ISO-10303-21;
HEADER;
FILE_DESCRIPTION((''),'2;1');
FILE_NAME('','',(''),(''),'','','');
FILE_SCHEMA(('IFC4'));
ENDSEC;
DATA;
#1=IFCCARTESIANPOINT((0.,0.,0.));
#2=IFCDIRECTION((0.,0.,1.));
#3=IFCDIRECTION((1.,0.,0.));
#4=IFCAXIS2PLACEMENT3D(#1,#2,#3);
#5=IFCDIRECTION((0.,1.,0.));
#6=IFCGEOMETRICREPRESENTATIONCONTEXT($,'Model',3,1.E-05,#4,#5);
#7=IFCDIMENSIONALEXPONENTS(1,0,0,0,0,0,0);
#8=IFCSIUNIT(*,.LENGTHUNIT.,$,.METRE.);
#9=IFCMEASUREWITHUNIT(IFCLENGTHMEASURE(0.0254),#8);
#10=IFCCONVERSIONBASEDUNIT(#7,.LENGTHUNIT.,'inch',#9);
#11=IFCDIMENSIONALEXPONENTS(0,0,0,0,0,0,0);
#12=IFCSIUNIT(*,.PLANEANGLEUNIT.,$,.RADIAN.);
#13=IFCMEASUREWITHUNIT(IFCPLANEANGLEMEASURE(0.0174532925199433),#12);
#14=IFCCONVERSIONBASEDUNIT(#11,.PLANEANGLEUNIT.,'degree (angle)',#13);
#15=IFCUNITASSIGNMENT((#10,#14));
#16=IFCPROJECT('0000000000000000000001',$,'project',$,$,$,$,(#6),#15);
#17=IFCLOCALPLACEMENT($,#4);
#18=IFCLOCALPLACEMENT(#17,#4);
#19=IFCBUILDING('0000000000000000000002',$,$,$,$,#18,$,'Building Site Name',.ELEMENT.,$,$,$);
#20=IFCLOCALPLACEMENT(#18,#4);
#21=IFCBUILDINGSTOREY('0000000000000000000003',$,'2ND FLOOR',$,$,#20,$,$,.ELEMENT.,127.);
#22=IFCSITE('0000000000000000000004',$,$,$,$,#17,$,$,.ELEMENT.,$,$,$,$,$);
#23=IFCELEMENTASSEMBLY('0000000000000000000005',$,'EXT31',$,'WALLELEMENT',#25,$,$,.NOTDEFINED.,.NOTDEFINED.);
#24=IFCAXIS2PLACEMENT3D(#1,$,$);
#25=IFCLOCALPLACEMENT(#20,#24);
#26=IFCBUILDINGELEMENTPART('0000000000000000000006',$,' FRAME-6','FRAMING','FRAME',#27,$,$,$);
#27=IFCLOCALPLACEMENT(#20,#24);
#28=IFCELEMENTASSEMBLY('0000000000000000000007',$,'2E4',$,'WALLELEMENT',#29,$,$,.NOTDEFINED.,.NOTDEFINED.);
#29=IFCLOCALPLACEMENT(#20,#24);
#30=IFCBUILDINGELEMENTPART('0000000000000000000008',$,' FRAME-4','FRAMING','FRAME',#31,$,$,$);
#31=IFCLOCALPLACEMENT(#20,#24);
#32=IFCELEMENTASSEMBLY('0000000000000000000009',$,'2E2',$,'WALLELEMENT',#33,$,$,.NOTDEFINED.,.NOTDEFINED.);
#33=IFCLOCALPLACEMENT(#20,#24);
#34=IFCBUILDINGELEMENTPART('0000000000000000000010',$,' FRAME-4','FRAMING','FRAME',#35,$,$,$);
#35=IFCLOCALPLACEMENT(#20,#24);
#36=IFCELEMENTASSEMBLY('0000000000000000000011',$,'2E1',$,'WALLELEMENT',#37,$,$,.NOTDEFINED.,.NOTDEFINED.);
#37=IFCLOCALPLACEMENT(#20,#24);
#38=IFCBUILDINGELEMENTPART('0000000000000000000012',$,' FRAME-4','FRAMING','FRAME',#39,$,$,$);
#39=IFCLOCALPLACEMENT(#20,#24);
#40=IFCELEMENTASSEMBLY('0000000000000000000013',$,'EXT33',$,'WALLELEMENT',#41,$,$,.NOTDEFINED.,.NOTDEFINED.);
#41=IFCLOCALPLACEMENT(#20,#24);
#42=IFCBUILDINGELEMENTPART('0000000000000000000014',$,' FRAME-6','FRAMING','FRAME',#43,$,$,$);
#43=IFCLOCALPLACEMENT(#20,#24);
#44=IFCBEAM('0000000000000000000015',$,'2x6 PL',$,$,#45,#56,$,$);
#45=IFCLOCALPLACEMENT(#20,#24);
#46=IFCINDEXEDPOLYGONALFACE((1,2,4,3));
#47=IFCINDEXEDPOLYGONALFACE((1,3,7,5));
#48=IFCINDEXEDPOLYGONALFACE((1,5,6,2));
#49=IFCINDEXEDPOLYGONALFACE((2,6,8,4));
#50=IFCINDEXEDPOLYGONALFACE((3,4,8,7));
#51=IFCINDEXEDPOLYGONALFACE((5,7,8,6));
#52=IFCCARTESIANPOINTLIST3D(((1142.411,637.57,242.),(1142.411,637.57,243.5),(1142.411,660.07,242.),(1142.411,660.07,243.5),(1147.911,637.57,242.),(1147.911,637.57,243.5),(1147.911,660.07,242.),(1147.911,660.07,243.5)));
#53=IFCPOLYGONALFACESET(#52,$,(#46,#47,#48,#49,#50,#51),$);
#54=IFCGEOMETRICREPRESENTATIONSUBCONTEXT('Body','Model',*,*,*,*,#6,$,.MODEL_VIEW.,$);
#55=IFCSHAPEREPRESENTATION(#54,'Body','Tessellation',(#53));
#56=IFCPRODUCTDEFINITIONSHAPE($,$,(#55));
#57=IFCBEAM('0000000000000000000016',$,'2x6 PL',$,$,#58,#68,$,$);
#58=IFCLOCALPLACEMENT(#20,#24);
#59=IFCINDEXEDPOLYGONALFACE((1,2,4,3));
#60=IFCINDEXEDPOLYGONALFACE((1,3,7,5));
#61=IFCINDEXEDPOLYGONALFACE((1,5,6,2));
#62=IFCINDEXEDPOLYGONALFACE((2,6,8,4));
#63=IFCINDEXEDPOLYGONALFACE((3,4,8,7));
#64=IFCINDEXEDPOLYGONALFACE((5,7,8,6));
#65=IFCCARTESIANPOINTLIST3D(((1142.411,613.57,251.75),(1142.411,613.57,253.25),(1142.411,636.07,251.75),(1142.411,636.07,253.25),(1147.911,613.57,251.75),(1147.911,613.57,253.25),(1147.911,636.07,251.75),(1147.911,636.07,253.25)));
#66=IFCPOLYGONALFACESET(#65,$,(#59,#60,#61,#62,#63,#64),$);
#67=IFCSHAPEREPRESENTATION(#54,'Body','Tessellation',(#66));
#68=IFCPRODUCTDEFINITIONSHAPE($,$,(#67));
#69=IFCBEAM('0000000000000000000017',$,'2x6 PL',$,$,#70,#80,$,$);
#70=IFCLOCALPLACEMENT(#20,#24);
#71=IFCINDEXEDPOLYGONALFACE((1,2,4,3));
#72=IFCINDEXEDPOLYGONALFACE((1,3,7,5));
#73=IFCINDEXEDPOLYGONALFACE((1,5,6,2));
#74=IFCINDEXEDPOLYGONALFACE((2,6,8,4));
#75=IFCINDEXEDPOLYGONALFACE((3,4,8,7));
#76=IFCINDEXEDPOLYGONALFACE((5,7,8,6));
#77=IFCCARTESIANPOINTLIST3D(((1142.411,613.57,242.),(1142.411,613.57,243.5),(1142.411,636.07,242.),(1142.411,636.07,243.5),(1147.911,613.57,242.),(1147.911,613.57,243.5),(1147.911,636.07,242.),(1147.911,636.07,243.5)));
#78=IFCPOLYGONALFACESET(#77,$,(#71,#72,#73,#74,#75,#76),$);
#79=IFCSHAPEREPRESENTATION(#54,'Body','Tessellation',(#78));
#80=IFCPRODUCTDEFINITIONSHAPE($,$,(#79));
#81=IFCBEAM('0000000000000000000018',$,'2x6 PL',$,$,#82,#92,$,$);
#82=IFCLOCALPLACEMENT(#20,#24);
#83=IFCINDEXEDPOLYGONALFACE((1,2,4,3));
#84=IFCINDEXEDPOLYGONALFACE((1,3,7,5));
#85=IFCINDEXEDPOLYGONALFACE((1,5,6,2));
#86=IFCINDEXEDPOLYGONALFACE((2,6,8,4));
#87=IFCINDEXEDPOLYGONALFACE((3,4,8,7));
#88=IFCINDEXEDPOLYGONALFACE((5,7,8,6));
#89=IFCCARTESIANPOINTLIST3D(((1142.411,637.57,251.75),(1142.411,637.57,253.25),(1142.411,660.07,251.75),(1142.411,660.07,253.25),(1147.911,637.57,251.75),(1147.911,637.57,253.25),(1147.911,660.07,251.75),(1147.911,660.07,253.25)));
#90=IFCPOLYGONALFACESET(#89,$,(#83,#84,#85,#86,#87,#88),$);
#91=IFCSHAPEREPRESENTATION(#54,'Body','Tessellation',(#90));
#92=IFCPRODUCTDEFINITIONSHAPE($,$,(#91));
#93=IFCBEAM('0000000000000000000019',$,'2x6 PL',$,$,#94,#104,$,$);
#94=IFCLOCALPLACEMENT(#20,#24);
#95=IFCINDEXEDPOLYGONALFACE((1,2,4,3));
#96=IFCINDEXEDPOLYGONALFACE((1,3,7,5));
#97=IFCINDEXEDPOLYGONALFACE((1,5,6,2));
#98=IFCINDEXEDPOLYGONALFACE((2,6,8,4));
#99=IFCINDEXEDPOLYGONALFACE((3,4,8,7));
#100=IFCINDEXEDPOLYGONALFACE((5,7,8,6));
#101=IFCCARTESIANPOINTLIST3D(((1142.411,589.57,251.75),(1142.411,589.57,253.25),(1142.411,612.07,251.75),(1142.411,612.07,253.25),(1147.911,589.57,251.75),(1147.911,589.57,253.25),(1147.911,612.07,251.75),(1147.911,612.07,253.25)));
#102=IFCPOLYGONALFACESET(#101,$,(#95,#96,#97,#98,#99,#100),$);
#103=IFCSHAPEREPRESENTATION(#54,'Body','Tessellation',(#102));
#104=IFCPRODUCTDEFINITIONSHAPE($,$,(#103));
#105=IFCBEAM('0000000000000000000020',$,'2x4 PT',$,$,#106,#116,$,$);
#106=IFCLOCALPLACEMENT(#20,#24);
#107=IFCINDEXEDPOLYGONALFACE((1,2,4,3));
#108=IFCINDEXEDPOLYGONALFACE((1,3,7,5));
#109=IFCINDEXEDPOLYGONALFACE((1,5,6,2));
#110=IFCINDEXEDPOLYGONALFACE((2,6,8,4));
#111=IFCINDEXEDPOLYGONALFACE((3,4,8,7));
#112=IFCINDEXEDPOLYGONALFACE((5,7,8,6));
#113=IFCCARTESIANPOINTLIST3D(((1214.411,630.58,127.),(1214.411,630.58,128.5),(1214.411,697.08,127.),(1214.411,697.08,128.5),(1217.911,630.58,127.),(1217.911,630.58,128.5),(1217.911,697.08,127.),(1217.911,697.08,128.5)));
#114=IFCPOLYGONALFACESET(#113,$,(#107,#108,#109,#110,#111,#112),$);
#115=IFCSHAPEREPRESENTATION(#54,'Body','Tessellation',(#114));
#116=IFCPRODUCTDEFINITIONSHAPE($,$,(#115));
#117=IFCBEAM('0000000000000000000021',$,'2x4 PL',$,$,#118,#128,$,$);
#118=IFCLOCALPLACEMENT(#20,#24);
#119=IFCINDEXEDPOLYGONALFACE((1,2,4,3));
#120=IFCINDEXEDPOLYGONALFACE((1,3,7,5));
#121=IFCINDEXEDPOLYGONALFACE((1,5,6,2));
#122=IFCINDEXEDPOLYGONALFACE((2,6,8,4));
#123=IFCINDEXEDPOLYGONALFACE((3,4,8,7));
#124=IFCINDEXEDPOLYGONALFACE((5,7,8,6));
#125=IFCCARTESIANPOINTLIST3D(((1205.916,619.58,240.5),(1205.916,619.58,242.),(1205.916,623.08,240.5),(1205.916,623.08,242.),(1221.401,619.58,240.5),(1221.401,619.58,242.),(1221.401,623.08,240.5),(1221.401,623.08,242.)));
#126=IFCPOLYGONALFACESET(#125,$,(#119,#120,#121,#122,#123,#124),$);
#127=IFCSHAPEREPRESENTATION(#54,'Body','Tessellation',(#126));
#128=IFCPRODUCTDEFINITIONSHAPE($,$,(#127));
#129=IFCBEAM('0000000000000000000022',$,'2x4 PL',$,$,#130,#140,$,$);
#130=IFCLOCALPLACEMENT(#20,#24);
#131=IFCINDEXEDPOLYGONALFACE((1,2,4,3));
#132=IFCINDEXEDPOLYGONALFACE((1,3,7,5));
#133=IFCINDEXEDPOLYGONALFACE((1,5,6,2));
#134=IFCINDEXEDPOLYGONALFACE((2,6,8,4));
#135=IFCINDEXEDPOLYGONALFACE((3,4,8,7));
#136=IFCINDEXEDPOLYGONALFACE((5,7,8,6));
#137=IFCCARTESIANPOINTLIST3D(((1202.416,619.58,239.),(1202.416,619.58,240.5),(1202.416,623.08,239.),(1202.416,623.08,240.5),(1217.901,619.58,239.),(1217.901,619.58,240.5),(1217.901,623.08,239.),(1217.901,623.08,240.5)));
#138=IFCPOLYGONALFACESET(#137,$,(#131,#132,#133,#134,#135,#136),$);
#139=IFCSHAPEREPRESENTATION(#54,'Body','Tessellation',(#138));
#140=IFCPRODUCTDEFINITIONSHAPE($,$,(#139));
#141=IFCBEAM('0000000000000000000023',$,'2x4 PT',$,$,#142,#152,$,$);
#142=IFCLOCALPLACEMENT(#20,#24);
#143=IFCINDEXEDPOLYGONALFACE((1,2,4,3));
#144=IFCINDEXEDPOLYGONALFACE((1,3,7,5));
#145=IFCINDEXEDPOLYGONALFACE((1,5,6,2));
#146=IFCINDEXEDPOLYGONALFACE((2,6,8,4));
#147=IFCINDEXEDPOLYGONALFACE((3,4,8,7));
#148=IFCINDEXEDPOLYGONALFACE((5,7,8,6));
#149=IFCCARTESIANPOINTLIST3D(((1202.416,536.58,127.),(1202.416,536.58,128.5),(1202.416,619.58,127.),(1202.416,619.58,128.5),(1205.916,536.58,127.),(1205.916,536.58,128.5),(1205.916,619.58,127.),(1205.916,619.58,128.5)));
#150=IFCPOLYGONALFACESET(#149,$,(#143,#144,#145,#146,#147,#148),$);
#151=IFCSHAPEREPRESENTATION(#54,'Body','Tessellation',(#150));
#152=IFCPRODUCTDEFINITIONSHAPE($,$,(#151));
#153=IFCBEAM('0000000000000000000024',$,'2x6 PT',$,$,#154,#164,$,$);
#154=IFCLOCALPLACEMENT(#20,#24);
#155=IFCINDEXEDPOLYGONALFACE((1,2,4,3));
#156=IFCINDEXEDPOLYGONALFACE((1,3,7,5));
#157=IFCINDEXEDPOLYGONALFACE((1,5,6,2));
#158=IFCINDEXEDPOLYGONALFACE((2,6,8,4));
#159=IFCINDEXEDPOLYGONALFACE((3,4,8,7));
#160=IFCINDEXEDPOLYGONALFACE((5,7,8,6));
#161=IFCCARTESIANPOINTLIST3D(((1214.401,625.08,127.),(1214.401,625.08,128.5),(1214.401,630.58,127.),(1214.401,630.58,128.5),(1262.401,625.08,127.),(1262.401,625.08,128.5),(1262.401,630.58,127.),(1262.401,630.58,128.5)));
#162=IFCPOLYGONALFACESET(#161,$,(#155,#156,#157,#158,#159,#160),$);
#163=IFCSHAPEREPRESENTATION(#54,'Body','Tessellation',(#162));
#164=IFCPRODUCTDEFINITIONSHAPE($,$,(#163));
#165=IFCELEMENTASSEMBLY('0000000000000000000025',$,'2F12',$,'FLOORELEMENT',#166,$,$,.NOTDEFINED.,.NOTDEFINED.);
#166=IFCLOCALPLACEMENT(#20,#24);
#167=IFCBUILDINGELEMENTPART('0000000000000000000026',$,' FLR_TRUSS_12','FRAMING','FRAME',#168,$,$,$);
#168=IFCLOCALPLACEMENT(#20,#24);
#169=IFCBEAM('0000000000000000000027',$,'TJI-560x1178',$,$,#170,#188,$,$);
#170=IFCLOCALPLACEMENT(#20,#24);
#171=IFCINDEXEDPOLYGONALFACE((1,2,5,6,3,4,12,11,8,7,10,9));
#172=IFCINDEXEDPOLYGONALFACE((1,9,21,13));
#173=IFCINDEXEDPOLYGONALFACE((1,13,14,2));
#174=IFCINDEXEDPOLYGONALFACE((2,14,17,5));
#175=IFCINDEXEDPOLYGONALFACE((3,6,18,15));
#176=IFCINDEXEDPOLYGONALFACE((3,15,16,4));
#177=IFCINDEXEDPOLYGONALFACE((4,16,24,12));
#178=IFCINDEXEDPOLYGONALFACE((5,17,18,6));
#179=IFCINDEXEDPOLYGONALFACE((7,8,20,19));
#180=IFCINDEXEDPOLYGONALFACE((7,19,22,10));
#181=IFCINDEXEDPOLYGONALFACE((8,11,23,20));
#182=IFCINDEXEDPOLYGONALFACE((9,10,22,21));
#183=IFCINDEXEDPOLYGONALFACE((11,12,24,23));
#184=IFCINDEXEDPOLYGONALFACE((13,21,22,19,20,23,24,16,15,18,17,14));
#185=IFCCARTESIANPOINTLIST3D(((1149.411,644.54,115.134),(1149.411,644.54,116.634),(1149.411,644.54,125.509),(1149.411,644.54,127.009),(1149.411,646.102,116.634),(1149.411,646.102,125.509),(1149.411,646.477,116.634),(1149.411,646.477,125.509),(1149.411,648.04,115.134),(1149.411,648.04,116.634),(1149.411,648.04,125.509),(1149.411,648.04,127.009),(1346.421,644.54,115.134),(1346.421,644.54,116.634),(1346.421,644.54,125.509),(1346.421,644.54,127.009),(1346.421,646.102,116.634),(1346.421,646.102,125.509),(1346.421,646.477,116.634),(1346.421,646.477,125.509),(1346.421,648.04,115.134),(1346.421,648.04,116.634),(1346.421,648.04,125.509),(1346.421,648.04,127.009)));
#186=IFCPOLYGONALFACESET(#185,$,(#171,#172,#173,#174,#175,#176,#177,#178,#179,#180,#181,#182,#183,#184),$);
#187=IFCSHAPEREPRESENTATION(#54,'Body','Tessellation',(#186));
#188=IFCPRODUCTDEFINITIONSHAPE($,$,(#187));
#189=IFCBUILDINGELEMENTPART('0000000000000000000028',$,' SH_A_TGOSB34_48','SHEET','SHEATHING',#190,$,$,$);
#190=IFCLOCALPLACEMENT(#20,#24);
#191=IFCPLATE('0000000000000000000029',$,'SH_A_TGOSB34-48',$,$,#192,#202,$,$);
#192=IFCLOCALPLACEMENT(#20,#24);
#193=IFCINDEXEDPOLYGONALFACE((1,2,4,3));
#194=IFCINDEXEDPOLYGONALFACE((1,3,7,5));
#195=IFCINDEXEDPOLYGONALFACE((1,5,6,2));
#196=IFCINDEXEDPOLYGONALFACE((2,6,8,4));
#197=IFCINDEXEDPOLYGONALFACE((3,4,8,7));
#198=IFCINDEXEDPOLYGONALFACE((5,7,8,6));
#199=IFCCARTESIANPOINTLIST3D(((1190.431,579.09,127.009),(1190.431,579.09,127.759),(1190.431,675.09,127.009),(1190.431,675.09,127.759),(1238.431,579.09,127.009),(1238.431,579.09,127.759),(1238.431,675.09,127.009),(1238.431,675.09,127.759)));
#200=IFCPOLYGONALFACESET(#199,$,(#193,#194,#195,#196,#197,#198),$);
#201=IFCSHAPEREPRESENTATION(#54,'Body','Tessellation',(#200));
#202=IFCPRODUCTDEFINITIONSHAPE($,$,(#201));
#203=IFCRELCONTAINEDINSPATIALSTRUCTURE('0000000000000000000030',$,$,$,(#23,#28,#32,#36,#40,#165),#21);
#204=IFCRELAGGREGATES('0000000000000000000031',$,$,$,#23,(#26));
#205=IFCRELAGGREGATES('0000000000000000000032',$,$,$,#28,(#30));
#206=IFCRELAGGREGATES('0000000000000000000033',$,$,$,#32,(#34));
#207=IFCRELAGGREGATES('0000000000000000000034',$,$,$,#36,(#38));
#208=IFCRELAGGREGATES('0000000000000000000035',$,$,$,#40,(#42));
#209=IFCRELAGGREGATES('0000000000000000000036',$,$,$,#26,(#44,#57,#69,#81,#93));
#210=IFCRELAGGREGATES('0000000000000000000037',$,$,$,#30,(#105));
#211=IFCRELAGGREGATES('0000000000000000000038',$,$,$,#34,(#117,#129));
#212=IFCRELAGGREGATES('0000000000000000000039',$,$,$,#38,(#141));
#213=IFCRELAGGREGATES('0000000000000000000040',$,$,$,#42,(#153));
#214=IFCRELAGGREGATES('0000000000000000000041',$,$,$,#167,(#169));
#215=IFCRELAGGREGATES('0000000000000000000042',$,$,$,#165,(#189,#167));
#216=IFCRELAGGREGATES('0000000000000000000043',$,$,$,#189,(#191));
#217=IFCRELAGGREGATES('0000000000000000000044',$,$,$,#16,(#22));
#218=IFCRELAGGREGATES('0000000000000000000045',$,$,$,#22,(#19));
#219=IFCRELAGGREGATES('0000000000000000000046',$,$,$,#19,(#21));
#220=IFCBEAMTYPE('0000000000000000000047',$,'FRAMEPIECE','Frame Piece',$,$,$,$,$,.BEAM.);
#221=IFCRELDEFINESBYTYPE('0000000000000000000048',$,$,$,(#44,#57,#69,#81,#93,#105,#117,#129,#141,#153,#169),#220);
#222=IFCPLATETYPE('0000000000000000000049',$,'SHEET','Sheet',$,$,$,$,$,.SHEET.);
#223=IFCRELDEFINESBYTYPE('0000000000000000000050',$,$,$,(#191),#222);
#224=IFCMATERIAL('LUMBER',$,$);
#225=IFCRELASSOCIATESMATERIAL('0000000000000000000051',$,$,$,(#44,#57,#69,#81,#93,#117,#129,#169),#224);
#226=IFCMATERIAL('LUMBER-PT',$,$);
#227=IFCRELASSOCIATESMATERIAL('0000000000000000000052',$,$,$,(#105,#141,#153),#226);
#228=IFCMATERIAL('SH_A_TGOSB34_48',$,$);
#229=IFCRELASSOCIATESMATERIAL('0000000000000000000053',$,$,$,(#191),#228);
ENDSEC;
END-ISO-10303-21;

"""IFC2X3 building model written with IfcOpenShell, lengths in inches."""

from ifc_helpers import new_model, entity, si_unit, converted_unit, direction, frame, frame_2d, origin_with_axes, origin_2d_with_axis, place, context, subcontext, project, spatial, rectangle, i_section, extrude, material, type_object, element, aggregate, save


model = new_model("IFC2X3")

# Units and contexts
model_context = context("Model", 3, precision=1e-05, world=origin_with_axes(), true_north=direction((0.0, 1.0, 0.0)))
body_context = subcontext(model_context, "Body", "Model", "MODEL_VIEW")
ifc_project = project(units=[converted_unit("LENGTHUNIT", "inch", entity("IfcLengthMeasure", 0.0254), si_unit("LENGTHUNIT", "METRE"), dimensions=[1, 0, 0, 0, 0, 0, 0]), converted_unit("PLANEANGLEUNIT", "degree (angle)", entity("IfcPlaneAngleMeasure", 0.0174532925199433), si_unit("PLANEANGLEUNIT", "RADIAN"), dimensions=[0, 0, 0, 0, 0, 0, 0])], contexts=[model_context])

# Site, building, storey
site_placement = place(None, origin_with_axes())
site = spatial("IfcSite", under=ifc_project, at=site_placement, CompositionType="ELEMENT")
building_placement = place(site_placement, origin_with_axes())
building = spatial("IfcBuilding", under=site, at=building_placement, LongName="Building Site Name", CompositionType="ELEMENT")
storey_placement = place(building_placement, origin_with_axes())
storey = spatial("IfcBuildingStorey", under=building, at=storey_placement, Name="2ND FLOOR", CompositionType="ELEMENT", Elevation=127.0)

# Element assemblies, building element parts
assembly_1_placement = place(storey_placement, origin_with_axes())
assembly_1 = element("IfcElementAssembly", 1, at=assembly_1_placement, inside=storey, Name="EXT31", ObjectType="WALLELEMENT", AssemblyPlace="NOTDEFINED", PredefinedType="NOTDEFINED")
building_element_part_1 = element("IfcBuildingElementPart", 2, Name=" FRAME-6", Description="FRAMING", ObjectType="FRAME")
aggregate(assembly_1, [building_element_part_1])
ifc_material_1 = material(Name="LUMBER")
beam_type_1 = type_object("IfcBeamType", Name="FRAMEPIECE", Description="Frame Piece", PredefinedType="BEAM")
assembly_2_placement = place(storey_placement, origin_with_axes())
assembly_2 = element("IfcElementAssembly", 3, at=assembly_2_placement, inside=storey, Name="2E4", ObjectType="WALLELEMENT", AssemblyPlace="NOTDEFINED", PredefinedType="NOTDEFINED")
building_element_part_2 = element("IfcBuildingElementPart", 4, Name=" FRAME-4", Description="FRAMING", ObjectType="FRAME")
aggregate(assembly_2, [building_element_part_2])
assembly_3_placement = place(storey_placement, origin_with_axes())
assembly_3 = element("IfcElementAssembly", 5, at=assembly_3_placement, inside=storey, Name="2E2", ObjectType="WALLELEMENT", AssemblyPlace="NOTDEFINED", PredefinedType="NOTDEFINED")
building_element_part_3 = element("IfcBuildingElementPart", 6, Name=" FRAME-4", Description="FRAMING", ObjectType="FRAME")
aggregate(assembly_3, [building_element_part_3])
assembly_4_placement = place(storey_placement, origin_with_axes())
assembly_4 = element("IfcElementAssembly", 7, at=assembly_4_placement, inside=storey, Name="2E1", ObjectType="WALLELEMENT", AssemblyPlace="NOTDEFINED", PredefinedType="NOTDEFINED")
building_element_part_4 = element("IfcBuildingElementPart", 8, Name=" FRAME-4", Description="FRAMING", ObjectType="FRAME")
aggregate(assembly_4, [building_element_part_4])

# Element assembly, building element part
assembly_5_placement = place(storey_placement, origin_with_axes())
assembly_5 = element("IfcElementAssembly", 9, at=assembly_5_placement, inside=storey, Name="EXT33", ObjectType="WALLELEMENT", AssemblyPlace="NOTDEFINED", PredefinedType="NOTDEFINED")
building_element_part_5 = element("IfcBuildingElementPart", 10, Name=" FRAME-6", Description="FRAMING", ObjectType="FRAME")
aggregate(assembly_5, [building_element_part_5])

# Beams
beam_1_placement = place(assembly_1_placement, frame((1145.161, 637.57, 242.75), z_axis=(0.0, 1.0, 0.0), x_axis=(0.0, 0.0, -1.0)))
beam_1 = element("IfcBeam", 11, at=beam_1_placement, type_object=beam_type_1, material=ifc_material_1, Name="2x6 PL", context=body_context, shape_type="SweptSolid", body=[
    extrude(rectangle(XDim=1.5, YDim=5.5, at=frame_2d((0.0, 0.0), x_axis=(-1.0, 0.0))), origin_with_axes(), (0.0, 0.0, 1.0), 22.5),
])
beam_2_placement = place(assembly_1_placement, frame((1145.161, 613.57, 252.5), z_axis=(0.0, 1.0, 0.0), x_axis=(0.0, 0.0, -1.0)))
beam_2 = element("IfcBeam", 12, at=beam_2_placement, type_object=beam_type_1, material=ifc_material_1, Name="2x6 PL", context=body_context, shape_type="SweptSolid", body=[
    extrude(rectangle(XDim=1.5, YDim=5.5, at=frame_2d((0.0, 0.0), x_axis=(-1.0, 0.0))), origin_with_axes(), (0.0, 0.0, 1.0), 22.5),
])
beam_3_placement = place(assembly_1_placement, frame((1145.161, 613.57, 242.75), z_axis=(0.0, 1.0, 0.0), x_axis=(0.0, 0.0, -1.0)))
beam_3 = element("IfcBeam", 13, at=beam_3_placement, type_object=beam_type_1, material=ifc_material_1, Name="2x6 PL", context=body_context, shape_type="SweptSolid", body=[
    extrude(rectangle(XDim=1.5, YDim=5.5, at=frame_2d((0.0, 0.0), x_axis=(-1.0, 0.0))), origin_with_axes(), (0.0, 0.0, 1.0), 22.5),
])
beam_4_placement = place(assembly_1_placement, frame((1145.161, 637.57, 252.5), z_axis=(0.0, 1.0, 0.0), x_axis=(0.0, 0.0, -1.0)))
beam_4 = element("IfcBeam", 14, at=beam_4_placement, type_object=beam_type_1, material=ifc_material_1, Name="2x6 PL", context=body_context, shape_type="SweptSolid", body=[
    extrude(rectangle(XDim=1.5, YDim=5.5, at=frame_2d((0.0, 0.0), x_axis=(-1.0, 0.0))), origin_with_axes(), (0.0, 0.0, 1.0), 22.5),
])
beam_5_placement = place(assembly_1_placement, frame((1145.161, 589.57, 252.5), z_axis=(0.0, 1.0, 0.0), x_axis=(0.0, 0.0, -1.0)))
beam_5 = element("IfcBeam", 15, at=beam_5_placement, type_object=beam_type_1, material=ifc_material_1, Name="2x6 PL", context=body_context, shape_type="SweptSolid", body=[
    extrude(rectangle(XDim=1.5, YDim=5.5, at=frame_2d((0.0, 0.0), x_axis=(-1.0, 0.0))), origin_with_axes(), (0.0, 0.0, 1.0), 22.5),
])
aggregate(building_element_part_1, [beam_1, beam_2, beam_3, beam_4, beam_5])
ifc_material_2 = material(Name="LUMBER-PT")
beam_6_placement = place(assembly_2_placement, frame((1216.161, 630.58, 127.75), z_axis=(0.0, 1.0, 0.0), x_axis=(0.0, 0.0, 1.0)))
beam_6 = element("IfcBeam", 16, at=beam_6_placement, type_object=beam_type_1, material=ifc_material_2, Name="2x4 PT", context=body_context, shape_type="SweptSolid", body=[
    extrude(rectangle(XDim=1.5, YDim=3.5, at=frame_2d((0.0, 0.0), x_axis=(-1.0, 0.0))), origin_with_axes(), (0.0, 0.0, 1.0), 66.5),
])
aggregate(building_element_part_2, [beam_6])
beam_7_placement = place(assembly_3_placement, frame((1205.916, 621.33, 241.25), z_axis=(1.0, 0.0, 0.0), x_axis=(0.0, 0.0, -1.0)))
beam_7 = element("IfcBeam", 17, at=beam_7_placement, type_object=beam_type_1, material=ifc_material_1, Name="2x4 PL", context=body_context, shape_type="SweptSolid", body=[
    extrude(rectangle(XDim=1.5, YDim=3.5, at=frame_2d((0.0, 0.0), x_axis=(-1.0, 0.0))), frame((0.0, 0.0, 0.0), z_axis=(0.0, 0.0, 1.0), x_axis=(1.0, 0.0, 0.0)), (0.0, 0.0, 1.0), 15.485),
])
beam_8_placement = place(assembly_3_placement, frame((1202.416, 621.33, 239.75), z_axis=(1.0, 0.0, 0.0), x_axis=(0.0, 0.0, -1.0)))
beam_8 = element("IfcBeam", 18, at=beam_8_placement, type_object=beam_type_1, material=ifc_material_1, Name="2x4 PL", context=body_context, shape_type="SweptSolid", body=[
    extrude(rectangle(XDim=1.5, YDim=3.5, at=frame_2d((0.0, 0.0), x_axis=(-1.0, 0.0))), frame((0.0, 0.0, 0.0), z_axis=(0.0, 0.0, 1.0), x_axis=(1.0, 0.0, 0.0)), (0.0, 0.0, 1.0), 15.485),
])
aggregate(building_element_part_3, [beam_7, beam_8])
beam_9_placement = place(assembly_4_placement, frame((1204.166, 619.58, 127.75), z_axis=(0.0, -1.0, 0.0), x_axis=(0.0, 0.0, 1.0)))
beam_9 = element("IfcBeam", 19, at=beam_9_placement, type_object=beam_type_1, material=ifc_material_2, Name="2x4 PT", context=body_context, shape_type="SweptSolid", body=[
    extrude(rectangle(XDim=1.5, YDim=3.5, at=frame_2d((0.0, 0.0), x_axis=(-1.0, 0.0))), origin_with_axes(), (0.0, 0.0, 1.0), 83.0),
])
aggregate(building_element_part_4, [beam_9])
beam_10_placement = place(assembly_5_placement, frame((1214.401, 627.83, 127.75), z_axis=(1.0, 0.0, 0.0), x_axis=(0.0, 0.0, 1.0)))
beam_10 = element("IfcBeam", 20, at=beam_10_placement, type_object=beam_type_1, material=ifc_material_2, Name="2x6 PT", context=body_context, shape_type="SweptSolid", body=[
    extrude(rectangle(XDim=1.5, YDim=5.5, at=frame_2d((0.0, 0.0), x_axis=(-1.0, 0.0))), frame((0.0, 0.0, 0.0), z_axis=(0.0, 0.0, 1.0), x_axis=(1.0, 0.0, 0.0)), (0.0, 0.0, 1.0), 48.0),
])
aggregate(building_element_part_5, [beam_10])

# Element assembly, building element parts, beam, plate
assembly_6_placement = place(storey_placement, origin_with_axes())
assembly_6 = element("IfcElementAssembly", 21, at=assembly_6_placement, inside=storey, Name="2F12", ObjectType="FLOORELEMENT", AssemblyPlace="NOTDEFINED", PredefinedType="NOTDEFINED")
building_element_part_6 = element("IfcBuildingElementPart", 22, Name=" FLR_TRUSS_12", Description="FRAMING", ObjectType="FRAME")
beam_11_placement = place(assembly_6_placement, frame((1149.411, 646.29, 121.071), z_axis=(1.0, 0.0, 0.0), x_axis=(0.0, 1.0, 0.0)))
beam_11 = element("IfcBeam", 23, at=beam_11_placement, type_object=beam_type_1, material=ifc_material_1, Name="TJI-560x1178", context=body_context, shape_type="SweptSolid", body=[
    extrude(i_section(OverallWidth=3.5, OverallDepth=11.875, WebThickness=0.375, FlangeThickness=1.5, FilletRadius=0.0, at=origin_2d_with_axis()), frame((0.0, 0.0, 0.0), z_axis=(0.0, 0.0, 1.0), x_axis=(1.0, 0.0, 0.0)), (0.0, 0.0, 1.0), 197.01),
])
aggregate(building_element_part_6, [beam_11])
building_element_part_7 = element("IfcBuildingElementPart", 24, Name=" SH_A_TGOSB34_48", Description="SHEET", ObjectType="SHEATHING")
aggregate(assembly_6, [building_element_part_7, building_element_part_6])
ifc_material_3 = material(Name="SH_A_TGOSB34_48")
plate_type = type_object("IfcPlateType", Name="SHEET", Description="Sheet", PredefinedType="SHEET")
plate_placement = place(assembly_6_placement, frame((1214.431, 627.09, 127.759), z_axis=(0.0, 0.0, 1.0), x_axis=(1.0, 0.0, 0.0)))
plate = element("IfcPlate", 25, at=plate_placement, type_object=plate_type, material=ifc_material_3, Name="SH_A_TGOSB34-48", context=body_context, shape_type="SweptSolid", body=[
    extrude(rectangle(XDim=0.75, YDim=48.0, at=frame_2d((0.0, -0.375), x_axis=(0.0, -1.0))), frame((0.0, -48.0, 0.0), z_axis=(0.0, 1.0, 0.0), x_axis=(-1.0, 0.0, 0.0)), (0.0, 0.0, 1.0), 96.0),
])
aggregate(building_element_part_7, [plate])

save(model, "model.ifc")
